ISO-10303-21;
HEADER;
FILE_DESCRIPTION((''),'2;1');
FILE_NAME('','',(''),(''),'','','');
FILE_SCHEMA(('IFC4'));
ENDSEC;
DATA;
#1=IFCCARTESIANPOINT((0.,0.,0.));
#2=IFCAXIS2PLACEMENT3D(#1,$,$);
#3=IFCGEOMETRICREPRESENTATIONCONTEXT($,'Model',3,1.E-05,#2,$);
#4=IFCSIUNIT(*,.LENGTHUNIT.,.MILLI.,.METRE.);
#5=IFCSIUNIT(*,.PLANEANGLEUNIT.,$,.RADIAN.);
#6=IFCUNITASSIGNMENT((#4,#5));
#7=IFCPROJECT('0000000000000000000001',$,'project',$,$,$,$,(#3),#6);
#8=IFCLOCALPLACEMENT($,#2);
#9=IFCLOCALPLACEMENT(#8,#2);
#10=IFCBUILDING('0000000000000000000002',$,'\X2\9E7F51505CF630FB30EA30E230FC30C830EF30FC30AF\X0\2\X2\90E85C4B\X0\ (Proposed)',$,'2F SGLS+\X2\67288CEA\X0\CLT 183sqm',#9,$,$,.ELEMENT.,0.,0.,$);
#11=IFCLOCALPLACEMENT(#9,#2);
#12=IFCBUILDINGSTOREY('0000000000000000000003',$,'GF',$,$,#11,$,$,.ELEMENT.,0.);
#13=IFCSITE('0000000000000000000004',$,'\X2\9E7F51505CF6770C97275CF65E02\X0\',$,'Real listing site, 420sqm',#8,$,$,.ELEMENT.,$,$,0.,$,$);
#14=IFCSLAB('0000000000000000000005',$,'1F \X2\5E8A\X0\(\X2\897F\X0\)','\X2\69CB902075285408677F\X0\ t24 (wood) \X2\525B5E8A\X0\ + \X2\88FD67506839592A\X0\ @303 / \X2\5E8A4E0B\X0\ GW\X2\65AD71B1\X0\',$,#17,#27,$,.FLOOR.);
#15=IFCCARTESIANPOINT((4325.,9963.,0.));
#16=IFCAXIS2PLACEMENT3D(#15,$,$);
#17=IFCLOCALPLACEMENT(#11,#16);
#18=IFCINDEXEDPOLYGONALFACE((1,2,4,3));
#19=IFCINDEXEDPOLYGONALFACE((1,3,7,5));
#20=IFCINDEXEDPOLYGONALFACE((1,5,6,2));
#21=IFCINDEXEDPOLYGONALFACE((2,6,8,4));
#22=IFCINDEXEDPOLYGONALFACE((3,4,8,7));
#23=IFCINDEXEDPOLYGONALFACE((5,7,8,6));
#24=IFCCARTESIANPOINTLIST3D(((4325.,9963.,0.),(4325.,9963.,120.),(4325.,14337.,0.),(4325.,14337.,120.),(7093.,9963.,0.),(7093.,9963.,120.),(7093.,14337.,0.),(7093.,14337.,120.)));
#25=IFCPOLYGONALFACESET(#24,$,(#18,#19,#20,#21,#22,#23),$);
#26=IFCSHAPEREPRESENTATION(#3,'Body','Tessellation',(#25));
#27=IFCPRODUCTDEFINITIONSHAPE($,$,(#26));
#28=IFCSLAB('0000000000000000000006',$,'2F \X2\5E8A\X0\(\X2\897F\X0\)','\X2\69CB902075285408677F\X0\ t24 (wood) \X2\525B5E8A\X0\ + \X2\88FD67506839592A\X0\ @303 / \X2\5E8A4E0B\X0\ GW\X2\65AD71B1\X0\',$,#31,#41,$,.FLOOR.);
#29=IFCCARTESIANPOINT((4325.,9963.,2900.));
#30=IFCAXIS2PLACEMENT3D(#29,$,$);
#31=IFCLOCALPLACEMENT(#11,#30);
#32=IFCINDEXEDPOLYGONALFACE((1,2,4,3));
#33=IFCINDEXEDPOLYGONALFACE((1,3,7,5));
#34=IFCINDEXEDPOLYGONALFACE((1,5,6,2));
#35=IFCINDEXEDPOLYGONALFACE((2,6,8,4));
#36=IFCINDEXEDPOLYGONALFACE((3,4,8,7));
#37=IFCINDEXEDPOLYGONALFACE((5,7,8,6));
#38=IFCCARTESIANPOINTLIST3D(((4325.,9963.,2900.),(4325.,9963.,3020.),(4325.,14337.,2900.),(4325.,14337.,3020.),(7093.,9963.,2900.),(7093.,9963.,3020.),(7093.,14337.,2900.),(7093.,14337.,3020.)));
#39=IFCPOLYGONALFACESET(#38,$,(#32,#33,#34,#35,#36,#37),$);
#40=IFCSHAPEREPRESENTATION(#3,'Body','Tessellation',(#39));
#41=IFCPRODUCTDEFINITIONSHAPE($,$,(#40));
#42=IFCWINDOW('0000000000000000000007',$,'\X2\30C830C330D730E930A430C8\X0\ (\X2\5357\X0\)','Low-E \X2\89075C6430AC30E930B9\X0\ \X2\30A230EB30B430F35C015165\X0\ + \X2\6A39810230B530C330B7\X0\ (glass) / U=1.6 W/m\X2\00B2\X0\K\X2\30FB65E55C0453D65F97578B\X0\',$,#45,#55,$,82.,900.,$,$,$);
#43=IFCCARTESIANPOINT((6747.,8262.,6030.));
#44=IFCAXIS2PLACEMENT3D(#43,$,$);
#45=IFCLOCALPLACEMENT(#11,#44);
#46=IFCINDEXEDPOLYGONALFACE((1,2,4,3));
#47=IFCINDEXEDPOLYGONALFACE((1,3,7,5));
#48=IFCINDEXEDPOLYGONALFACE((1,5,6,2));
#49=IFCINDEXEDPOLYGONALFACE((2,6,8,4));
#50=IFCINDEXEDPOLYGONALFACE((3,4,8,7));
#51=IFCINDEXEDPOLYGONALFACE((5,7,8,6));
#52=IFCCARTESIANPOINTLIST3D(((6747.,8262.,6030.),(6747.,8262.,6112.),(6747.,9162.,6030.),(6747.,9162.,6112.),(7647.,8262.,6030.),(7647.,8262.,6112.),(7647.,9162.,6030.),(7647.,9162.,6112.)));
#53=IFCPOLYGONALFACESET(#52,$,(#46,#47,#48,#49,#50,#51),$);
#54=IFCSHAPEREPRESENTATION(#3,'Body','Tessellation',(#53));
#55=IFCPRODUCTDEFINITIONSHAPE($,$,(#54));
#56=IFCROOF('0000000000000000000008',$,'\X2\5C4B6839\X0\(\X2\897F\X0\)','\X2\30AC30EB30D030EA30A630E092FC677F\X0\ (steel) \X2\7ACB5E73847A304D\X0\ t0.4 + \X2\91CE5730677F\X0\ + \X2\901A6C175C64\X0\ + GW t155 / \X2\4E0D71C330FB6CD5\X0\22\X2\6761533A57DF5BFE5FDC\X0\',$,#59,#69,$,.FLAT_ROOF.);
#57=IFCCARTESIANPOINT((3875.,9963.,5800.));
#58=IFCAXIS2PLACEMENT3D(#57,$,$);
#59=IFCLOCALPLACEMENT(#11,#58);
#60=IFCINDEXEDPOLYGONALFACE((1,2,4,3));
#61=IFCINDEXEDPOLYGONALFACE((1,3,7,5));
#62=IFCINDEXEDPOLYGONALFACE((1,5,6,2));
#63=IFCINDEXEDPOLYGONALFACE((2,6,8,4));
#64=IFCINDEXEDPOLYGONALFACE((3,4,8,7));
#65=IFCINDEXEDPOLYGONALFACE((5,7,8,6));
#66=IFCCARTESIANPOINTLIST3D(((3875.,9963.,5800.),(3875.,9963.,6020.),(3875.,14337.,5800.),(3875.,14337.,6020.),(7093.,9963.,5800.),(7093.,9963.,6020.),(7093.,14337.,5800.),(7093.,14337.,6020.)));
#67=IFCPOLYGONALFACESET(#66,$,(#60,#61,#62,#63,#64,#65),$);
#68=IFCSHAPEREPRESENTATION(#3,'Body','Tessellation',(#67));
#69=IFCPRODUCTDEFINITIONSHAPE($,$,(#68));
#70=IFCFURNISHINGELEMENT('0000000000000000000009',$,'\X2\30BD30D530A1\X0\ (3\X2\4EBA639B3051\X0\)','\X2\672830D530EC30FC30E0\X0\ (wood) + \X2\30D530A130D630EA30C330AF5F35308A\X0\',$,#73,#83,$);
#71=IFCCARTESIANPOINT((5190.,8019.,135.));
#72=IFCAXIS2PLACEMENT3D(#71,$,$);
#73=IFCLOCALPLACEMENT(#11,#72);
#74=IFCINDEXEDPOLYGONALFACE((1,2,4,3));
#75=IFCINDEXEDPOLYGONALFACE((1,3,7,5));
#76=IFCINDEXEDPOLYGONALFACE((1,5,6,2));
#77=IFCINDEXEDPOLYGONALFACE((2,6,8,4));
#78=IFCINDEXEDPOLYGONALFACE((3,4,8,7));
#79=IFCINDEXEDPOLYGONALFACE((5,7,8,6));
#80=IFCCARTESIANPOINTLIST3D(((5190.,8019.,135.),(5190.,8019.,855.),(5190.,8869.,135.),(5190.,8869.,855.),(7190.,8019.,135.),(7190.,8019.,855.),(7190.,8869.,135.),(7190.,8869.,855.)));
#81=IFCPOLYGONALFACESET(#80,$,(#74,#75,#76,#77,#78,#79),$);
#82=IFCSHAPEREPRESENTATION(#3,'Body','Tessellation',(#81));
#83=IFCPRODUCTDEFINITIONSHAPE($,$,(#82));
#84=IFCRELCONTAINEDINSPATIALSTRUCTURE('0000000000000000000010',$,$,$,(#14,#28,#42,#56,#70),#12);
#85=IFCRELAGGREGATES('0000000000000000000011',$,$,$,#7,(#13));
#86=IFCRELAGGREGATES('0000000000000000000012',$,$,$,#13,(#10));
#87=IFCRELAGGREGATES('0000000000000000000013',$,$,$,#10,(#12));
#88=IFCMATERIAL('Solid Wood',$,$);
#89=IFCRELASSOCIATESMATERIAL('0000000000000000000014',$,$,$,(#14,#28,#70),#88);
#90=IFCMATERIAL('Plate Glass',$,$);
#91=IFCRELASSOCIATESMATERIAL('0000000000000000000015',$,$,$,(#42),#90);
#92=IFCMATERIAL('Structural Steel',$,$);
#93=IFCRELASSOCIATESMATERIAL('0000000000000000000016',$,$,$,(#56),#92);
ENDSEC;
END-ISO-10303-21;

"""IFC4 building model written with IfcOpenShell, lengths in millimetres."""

from ifc_helpers import new_model, si_unit, frame, frame_2d, origin, place, context, project, spatial, rectangle, extrude, material, element, save


model = new_model("IFC4")

# Units and contexts
model_context = context("Model", 3, precision=1e-05, world=origin())
ifc_project = project(units=[si_unit("LENGTHUNIT", "METRE", prefix="MILLI"), si_unit("PLANEANGLEUNIT", "RADIAN")], contexts=[model_context])

# Site, building, storey
site_placement = place(None, origin())
site = spatial("IfcSite", under=ifc_project, at=site_placement, Name="鹿児島県霧島市", ObjectType="Real listing site, 420sqm", CompositionType="ELEMENT", RefElevation=0.0)
building_placement = place(site_placement, origin())
building = spatial("IfcBuilding", under=site, at=building_placement, Name="鹿児島・リモートワーク2部屋 (Proposed)", ObjectType="2F SGLS+木質CLT 183sqm", CompositionType="ELEMENT", ElevationOfRefHeight=0.0, ElevationOfTerrain=0.0)
storey_placement = place(building_placement, origin())
storey = spatial("IfcBuildingStorey", under=building, at=storey_placement, Name="GF", CompositionType="ELEMENT", Elevation=0.0)

# Shared definitions
ifc_material_1 = material(Name="Solid Wood")

# Slabs
slab_1_placement = place(storey_placement, frame((4325.0, 9963.0, 0.0)))
element("IfcSlab", 1, at=slab_1_placement, inside=storey, material=ifc_material_1, Name="1F 床(西)", Description="構造用合板 t24 (wood) 剛床 + 製材根太 @303 / 床下 GW断熱", PredefinedType="FLOOR", context=model_context, shape_type="SweptSolid", body=[
    extrude(rectangle(XDim=2768.0, YDim=4374.0, at=frame_2d((1384.0, 2187.0))), frame((4325.0, 9963.0, 0.0)), (0.0, 0.0, 1.0), 120.0),
])
slab_2_placement = place(storey_placement, frame((4325.0, 9963.0, 2900.0)))
element("IfcSlab", 2, at=slab_2_placement, inside=storey, material=ifc_material_1, Name="2F 床(西)", Description="構造用合板 t24 (wood) 剛床 + 製材根太 @303 / 床下 GW断熱", PredefinedType="FLOOR", context=model_context, shape_type="SweptSolid", body=[
    extrude(rectangle(XDim=2768.0, YDim=4374.0, at=frame_2d((1384.0, 2187.0))), frame((4325.0, 9963.0, 2900.0)), (0.0, 0.0, 1.0), 120.0),
])

# Window
ifc_material_2 = material(Name="Plate Glass")
window_placement = place(storey_placement, frame((6747.0, 8262.0, 6030.0)))
element("IfcWindow", 3, at=window_placement, inside=storey, material=ifc_material_2, Name="トップライト (南)", Description="Low-E 複層ガラス アルゴン封入 + 樹脂サッシ (glass) / U=1.6 W/m²K・日射取得型", OverallHeight=82.0, OverallWidth=900.0, context=model_context, shape_type="SweptSolid", body=[
    extrude(rectangle(XDim=900.0, YDim=900.0, at=frame_2d((450.0, 450.0))), frame((6747.0, 8262.0, 6030.0)), (0.0, 0.0, 1.0), 82.0),
])

# Roof
ifc_material_3 = material(Name="Structural Steel")
for number, where, name in (
    (4, (3875.0, 9963.0, 5800.0), "屋根(西)"),
):
    element("IfcRoof", number, at=place(storey_placement, frame(where)), inside=storey, material=ifc_material_3, Name=name, Description="ガルバリウム鋼板 (steel) 立平葺き t0.4 + 野地板 + 通気層 + GW t155 / 不燃・法22条区域対応", PredefinedType="FLAT_ROOF", context=model_context, shape_type="SweptSolid", body=[
        extrude(rectangle(XDim=3218.0, YDim=4374.0, at=frame_2d((1609.0, 2187.0))), frame((3875.0, 9963.0, 5800.0)), (0.0, 0.0, 1.0), 220.0),
    ])

# Furnishing element
furnishing_placement = place(storey_placement, frame((5190.0, 8019.0, 135.0)))
element("IfcFurnishingElement", 5, at=furnishing_placement, inside=storey, material=ifc_material_1, Name="ソファ (3人掛け)", Description="木フレーム (wood) + ファブリック張り", context=model_context, shape_type="SweptSolid", body=[
    extrude(rectangle(XDim=2000.0, YDim=850.0, at=frame_2d((1000.0, 425.0))), frame((5190.0, 8019.0, 135.0)), (0.0, 0.0, 1.0), 720.0),
])

save(model, "model.ifc")
